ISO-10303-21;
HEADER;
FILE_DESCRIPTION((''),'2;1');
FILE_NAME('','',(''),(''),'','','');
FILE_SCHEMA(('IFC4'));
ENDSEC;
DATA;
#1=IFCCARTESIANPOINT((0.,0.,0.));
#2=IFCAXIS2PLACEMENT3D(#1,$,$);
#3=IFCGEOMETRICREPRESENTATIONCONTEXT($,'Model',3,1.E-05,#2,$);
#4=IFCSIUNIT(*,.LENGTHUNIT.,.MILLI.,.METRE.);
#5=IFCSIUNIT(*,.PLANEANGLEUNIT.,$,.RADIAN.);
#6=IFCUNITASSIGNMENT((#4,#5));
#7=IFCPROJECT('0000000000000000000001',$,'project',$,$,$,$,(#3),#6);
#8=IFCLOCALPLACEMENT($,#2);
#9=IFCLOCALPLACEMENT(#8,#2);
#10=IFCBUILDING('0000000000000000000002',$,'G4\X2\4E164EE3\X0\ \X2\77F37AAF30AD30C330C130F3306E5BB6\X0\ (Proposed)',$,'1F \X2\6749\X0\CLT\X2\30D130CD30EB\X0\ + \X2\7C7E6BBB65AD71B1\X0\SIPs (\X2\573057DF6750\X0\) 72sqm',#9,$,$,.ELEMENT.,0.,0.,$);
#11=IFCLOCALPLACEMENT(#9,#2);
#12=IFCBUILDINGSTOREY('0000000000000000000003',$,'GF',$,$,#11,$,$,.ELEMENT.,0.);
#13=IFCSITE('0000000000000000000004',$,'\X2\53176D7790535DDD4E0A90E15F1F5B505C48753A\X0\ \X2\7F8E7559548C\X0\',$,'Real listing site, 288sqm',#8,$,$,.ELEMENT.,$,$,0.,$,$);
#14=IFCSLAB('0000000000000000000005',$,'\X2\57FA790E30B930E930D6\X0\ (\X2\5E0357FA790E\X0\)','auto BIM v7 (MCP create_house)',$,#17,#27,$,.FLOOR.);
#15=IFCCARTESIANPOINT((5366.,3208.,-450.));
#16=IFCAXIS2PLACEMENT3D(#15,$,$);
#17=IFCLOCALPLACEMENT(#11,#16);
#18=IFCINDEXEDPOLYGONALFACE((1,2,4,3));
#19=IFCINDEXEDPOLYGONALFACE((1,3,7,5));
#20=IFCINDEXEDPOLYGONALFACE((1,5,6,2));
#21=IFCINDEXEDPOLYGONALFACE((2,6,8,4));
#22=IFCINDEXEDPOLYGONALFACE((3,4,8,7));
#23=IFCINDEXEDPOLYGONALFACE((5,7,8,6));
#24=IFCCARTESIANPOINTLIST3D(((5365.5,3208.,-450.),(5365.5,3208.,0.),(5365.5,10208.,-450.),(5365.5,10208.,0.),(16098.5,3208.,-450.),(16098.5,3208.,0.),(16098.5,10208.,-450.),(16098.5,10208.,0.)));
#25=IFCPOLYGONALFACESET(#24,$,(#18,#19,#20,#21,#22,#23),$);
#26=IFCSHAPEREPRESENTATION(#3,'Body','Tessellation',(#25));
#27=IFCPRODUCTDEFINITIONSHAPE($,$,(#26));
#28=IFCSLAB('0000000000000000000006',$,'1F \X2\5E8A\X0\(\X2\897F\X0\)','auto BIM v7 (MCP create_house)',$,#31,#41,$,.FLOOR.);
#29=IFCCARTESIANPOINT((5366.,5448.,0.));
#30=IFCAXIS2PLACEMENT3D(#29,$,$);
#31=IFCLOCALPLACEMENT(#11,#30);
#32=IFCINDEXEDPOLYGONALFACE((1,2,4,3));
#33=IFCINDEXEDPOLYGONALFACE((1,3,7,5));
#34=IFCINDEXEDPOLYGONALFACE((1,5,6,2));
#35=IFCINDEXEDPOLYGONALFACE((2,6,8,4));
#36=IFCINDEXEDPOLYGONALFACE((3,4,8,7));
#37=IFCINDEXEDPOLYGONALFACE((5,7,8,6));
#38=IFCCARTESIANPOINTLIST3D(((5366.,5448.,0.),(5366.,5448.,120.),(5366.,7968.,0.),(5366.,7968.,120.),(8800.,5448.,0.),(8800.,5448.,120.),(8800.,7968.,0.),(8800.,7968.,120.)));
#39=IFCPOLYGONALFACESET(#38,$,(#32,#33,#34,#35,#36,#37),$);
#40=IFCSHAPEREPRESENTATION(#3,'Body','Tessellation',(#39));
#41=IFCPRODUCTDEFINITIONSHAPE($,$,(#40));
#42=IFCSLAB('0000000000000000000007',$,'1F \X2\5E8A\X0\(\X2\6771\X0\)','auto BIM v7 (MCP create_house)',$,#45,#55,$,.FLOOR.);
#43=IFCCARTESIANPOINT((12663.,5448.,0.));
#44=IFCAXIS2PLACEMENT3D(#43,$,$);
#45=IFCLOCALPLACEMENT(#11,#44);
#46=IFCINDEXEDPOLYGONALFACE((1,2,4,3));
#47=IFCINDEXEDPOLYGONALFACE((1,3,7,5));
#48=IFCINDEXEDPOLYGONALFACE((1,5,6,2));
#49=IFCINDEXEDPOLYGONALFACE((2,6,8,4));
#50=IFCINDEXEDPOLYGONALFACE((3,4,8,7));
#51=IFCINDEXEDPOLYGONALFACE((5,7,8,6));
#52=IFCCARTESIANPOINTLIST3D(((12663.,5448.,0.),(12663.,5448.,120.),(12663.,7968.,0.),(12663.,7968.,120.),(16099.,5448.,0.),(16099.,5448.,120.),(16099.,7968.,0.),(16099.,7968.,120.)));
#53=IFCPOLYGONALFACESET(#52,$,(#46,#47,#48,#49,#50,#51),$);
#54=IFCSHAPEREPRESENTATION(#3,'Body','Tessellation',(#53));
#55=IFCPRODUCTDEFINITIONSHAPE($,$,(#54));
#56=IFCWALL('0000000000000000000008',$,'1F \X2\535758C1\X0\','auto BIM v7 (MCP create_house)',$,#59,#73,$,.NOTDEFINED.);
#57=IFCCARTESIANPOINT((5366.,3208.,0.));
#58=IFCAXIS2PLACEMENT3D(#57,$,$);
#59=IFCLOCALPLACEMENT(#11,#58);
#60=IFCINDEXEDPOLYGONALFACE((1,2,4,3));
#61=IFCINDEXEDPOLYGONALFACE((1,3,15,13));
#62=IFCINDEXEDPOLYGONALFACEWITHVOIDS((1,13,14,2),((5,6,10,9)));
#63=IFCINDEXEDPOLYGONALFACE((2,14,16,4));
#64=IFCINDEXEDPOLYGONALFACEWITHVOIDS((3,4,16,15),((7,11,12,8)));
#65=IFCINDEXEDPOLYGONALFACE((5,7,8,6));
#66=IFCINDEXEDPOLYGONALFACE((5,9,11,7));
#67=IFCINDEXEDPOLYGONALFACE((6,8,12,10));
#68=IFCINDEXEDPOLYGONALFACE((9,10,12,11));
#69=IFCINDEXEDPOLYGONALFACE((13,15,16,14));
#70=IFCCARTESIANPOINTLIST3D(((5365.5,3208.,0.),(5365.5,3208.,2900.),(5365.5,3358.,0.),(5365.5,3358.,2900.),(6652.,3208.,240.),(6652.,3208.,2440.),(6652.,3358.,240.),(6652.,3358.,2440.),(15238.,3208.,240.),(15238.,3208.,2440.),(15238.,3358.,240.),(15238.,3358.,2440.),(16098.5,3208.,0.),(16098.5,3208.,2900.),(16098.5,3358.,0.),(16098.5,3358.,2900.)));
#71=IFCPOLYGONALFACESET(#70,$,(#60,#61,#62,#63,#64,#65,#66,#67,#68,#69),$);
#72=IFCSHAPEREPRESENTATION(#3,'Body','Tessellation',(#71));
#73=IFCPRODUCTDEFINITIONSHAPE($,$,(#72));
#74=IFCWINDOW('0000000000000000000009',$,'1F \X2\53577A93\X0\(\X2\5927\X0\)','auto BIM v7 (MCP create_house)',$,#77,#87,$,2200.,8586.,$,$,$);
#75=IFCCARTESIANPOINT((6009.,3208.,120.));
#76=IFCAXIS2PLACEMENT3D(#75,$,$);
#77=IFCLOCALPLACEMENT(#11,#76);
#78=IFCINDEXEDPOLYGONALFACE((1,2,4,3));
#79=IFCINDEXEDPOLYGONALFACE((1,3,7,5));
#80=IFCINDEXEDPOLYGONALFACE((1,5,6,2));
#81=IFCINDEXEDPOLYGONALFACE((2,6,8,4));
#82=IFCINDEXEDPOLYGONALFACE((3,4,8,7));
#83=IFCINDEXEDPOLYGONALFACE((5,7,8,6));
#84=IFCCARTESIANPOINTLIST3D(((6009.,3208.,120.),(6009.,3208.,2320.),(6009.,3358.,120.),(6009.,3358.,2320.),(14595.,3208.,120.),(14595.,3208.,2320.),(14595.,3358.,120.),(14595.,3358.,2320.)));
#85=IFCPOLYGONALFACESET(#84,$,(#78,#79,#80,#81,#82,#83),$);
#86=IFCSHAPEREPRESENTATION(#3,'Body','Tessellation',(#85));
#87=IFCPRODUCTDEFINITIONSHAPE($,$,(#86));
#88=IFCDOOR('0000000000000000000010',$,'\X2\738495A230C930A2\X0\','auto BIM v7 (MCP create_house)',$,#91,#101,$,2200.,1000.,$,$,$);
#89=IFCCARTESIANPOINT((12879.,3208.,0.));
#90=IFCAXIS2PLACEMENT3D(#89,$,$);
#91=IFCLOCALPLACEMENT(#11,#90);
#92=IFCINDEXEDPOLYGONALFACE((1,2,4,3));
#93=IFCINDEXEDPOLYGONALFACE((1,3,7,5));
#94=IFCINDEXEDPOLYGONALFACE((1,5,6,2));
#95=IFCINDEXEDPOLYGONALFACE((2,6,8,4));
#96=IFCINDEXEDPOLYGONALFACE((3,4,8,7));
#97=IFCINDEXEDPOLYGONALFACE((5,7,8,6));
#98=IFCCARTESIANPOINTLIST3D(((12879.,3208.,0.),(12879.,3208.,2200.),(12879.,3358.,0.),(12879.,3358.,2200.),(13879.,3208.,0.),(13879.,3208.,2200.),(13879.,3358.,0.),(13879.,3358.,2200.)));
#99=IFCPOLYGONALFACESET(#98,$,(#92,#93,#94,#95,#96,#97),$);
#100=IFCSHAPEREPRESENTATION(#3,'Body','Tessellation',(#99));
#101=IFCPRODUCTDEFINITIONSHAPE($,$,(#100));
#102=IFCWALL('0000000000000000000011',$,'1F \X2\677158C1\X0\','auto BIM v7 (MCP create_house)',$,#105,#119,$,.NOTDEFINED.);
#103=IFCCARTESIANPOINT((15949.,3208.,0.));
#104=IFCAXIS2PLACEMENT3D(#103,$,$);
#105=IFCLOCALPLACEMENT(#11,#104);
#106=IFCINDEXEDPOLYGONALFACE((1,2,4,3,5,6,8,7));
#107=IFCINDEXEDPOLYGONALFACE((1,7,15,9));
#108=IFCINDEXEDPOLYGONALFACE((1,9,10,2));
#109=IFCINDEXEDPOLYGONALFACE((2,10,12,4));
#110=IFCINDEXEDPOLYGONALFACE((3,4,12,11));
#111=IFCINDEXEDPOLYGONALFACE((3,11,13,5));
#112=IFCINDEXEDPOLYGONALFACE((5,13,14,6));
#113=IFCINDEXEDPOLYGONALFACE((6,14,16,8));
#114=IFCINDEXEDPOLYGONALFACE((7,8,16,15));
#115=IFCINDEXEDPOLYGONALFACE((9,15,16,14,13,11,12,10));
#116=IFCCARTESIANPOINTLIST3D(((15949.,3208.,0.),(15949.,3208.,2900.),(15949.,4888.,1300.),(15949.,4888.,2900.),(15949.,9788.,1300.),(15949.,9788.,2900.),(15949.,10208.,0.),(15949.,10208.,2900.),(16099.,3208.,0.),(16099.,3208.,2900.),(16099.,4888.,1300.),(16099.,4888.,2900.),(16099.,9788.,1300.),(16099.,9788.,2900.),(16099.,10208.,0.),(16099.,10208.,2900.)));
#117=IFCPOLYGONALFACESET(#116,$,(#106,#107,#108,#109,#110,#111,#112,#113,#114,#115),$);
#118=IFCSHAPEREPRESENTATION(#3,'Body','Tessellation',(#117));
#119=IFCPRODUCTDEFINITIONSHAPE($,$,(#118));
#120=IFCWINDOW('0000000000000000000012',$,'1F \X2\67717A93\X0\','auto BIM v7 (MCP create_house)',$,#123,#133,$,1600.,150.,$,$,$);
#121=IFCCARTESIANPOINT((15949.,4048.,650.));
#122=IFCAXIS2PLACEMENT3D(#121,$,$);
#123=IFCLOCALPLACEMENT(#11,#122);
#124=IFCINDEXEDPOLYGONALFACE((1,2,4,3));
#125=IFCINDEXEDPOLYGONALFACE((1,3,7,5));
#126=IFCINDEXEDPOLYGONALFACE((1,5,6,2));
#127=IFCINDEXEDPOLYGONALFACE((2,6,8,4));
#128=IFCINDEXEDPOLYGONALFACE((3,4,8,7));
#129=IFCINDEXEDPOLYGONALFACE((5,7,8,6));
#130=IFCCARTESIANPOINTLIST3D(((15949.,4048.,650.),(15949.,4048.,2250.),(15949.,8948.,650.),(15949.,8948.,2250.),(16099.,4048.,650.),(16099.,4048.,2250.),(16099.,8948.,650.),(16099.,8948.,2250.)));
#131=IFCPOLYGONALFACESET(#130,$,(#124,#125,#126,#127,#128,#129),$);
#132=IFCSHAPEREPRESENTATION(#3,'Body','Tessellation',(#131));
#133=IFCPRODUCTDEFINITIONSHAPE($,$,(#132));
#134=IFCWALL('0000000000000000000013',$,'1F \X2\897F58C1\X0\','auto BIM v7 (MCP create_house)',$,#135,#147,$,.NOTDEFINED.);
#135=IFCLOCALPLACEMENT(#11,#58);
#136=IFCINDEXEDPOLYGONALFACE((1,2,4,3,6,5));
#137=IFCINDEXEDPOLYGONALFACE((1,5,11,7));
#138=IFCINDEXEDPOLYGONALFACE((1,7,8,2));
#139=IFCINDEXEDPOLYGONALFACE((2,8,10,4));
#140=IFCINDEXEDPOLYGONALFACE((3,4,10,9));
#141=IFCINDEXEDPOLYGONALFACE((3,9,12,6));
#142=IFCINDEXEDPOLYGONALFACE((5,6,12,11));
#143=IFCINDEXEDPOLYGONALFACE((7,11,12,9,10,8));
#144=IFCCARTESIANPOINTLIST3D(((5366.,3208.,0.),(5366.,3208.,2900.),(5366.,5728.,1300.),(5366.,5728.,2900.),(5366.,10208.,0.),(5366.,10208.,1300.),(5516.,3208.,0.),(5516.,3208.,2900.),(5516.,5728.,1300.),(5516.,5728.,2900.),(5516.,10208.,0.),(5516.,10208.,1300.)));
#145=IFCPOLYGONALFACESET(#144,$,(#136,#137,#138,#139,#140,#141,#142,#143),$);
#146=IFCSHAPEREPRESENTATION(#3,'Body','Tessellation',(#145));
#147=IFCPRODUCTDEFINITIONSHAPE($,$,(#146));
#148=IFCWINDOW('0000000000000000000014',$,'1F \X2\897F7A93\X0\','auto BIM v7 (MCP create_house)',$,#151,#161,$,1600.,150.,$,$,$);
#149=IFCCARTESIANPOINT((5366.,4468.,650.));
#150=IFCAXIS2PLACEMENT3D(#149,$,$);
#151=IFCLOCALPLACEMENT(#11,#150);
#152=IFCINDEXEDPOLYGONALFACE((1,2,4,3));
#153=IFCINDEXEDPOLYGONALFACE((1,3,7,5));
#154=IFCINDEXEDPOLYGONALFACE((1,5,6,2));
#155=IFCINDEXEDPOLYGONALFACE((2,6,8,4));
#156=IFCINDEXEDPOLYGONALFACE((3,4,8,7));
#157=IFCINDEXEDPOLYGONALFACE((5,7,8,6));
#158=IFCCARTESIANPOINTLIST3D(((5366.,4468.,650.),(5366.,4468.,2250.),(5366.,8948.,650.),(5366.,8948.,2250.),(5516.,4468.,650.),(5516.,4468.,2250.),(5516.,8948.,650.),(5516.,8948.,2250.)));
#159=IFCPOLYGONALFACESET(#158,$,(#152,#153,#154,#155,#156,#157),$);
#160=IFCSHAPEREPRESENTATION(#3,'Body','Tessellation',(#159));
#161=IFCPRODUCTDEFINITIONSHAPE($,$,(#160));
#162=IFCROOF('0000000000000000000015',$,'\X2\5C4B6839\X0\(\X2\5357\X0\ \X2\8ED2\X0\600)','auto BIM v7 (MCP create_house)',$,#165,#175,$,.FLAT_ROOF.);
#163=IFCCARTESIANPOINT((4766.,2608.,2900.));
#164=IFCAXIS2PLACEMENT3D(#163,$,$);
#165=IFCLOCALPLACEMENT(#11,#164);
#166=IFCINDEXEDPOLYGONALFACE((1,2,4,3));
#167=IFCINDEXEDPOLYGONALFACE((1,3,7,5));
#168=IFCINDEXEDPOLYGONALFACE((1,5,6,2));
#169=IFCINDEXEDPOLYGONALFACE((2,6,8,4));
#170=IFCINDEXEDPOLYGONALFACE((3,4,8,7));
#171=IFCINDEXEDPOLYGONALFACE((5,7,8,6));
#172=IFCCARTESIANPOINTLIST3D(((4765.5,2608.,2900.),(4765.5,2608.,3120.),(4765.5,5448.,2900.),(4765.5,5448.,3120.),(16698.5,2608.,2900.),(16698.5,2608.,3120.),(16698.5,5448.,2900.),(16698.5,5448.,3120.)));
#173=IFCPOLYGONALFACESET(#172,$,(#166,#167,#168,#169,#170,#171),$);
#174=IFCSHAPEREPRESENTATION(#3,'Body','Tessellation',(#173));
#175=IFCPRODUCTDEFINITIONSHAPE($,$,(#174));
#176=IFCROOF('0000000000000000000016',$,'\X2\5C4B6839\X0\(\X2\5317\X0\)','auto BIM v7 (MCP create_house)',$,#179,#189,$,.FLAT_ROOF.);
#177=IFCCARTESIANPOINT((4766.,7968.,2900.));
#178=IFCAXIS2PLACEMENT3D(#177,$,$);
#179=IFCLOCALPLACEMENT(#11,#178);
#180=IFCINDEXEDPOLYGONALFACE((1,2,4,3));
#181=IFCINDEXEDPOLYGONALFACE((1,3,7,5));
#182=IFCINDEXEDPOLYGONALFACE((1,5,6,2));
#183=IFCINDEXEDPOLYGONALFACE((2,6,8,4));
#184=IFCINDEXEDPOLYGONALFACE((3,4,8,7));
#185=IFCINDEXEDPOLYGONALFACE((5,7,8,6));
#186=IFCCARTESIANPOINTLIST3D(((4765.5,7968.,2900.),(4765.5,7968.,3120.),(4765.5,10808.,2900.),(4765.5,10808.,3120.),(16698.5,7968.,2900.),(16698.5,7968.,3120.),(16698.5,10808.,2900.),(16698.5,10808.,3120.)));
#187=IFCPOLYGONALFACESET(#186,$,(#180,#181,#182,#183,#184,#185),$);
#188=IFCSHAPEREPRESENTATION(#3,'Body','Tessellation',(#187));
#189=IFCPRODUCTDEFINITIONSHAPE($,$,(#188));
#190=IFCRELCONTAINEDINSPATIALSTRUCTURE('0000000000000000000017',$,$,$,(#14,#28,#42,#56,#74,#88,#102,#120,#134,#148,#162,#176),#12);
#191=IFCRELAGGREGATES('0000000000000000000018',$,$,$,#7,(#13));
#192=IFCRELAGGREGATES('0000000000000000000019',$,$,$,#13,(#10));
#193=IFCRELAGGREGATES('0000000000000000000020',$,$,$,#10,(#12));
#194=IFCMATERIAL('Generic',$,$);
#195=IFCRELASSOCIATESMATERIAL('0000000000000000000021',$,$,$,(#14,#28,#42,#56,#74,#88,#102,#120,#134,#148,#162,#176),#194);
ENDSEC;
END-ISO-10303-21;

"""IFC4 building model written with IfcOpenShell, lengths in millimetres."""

from ifc_helpers import new_model, si_unit, frame, frame_2d, origin, place, context, project, spatial, rectangle, extrude, material, element, fill, save


model = new_model("IFC4")

# Units and contexts
model_context = context("Model", 3, precision=1e-05, world=origin())
ifc_project = project(units=[si_unit("LENGTHUNIT", "METRE", prefix="MILLI"), si_unit("PLANEANGLEUNIT", "RADIAN")], contexts=[model_context])

# Site, building, storey
site_placement = place(None, origin())
site = spatial("IfcSite", under=ifc_project, at=site_placement, Name="北海道川上郡弟子屈町 美留和", ObjectType="Real listing site, 288sqm", CompositionType="ELEMENT", RefElevation=0.0)
building_placement = place(site_placement, origin())
building = spatial("IfcBuilding", under=site, at=building_placement, Name="G4世代 石窯キッチンの家 (Proposed)", ObjectType="1F 杉CLTパネル + 籾殻断熱SIPs (地域材) 72sqm", CompositionType="ELEMENT", ElevationOfRefHeight=0.0, ElevationOfTerrain=0.0)
storey_placement = place(building_placement, origin())
storey = spatial("IfcBuildingStorey", under=building, at=storey_placement, Name="GF", CompositionType="ELEMENT", Elevation=0.0)

# Slabs
ifc_material = material(Name="Generic")
slab_1_placement = place(storey_placement, frame((5366.0, 3208.0, -450.0)))
element("IfcSlab", 1, at=slab_1_placement, inside=storey, material=ifc_material, Name="基礎スラブ (布基礎)", Description="auto BIM v7 (MCP create_house)", PredefinedType="FLOOR", context=model_context, shape_type="SweptSolid", body=[
    extrude(rectangle(XDim=10733.0, YDim=7000.0, at=frame_2d((5366.0, 3500.0))), frame((5366.0, 3208.0, -450.0)), (0.0, 0.0, 1.0), 450.0),
])
slab_2_placement = place(storey_placement, frame((5366.0, 5448.0, 0.0)))
element("IfcSlab", 2, at=slab_2_placement, inside=storey, material=ifc_material, Name="1F 床(西)", Description="auto BIM v7 (MCP create_house)", PredefinedType="FLOOR", context=model_context, shape_type="SweptSolid", body=[
    extrude(rectangle(XDim=3434.0, YDim=2520.0, at=frame_2d((1717.0, 1260.0))), frame((5366.0, 5448.0, 0.0)), (0.0, 0.0, 1.0), 120.0),
])
slab_3_placement = place(storey_placement, frame((12663.0, 5448.0, 0.0)))
element("IfcSlab", 3, at=slab_3_placement, inside=storey, material=ifc_material, Name="1F 床(東)", Description="auto BIM v7 (MCP create_house)", PredefinedType="FLOOR", context=model_context, shape_type="SweptSolid", body=[
    extrude(rectangle(XDim=3436.0, YDim=2520.0, at=frame_2d((1718.0, 1260.0))), frame((12663.0, 5448.0, 0.0)), (0.0, 0.0, 1.0), 120.0),
])

# Wall, openings, window, door
wall_1_placement = place(storey_placement, frame((5366.0, 3208.0, 0.0)))
wall_1 = element("IfcWall", 4, at=wall_1_placement, inside=storey, material=ifc_material, Name="1F 南壁", Description="auto BIM v7 (MCP create_house)", PredefinedType="NOTDEFINED", context=model_context, shape_type="SweptSolid", body=[
    extrude(rectangle(XDim=10733.0, YDim=150.0, at=frame_2d((5366.0, 75.0))), frame((5366.0, 3208.0, 0.0)), (0.0, 0.0, 1.0), 2900.0),
])
opening_1_placement = place(storey_placement, frame((6009.0, 3208.0, 120.0)))
opening_1 = element("IfcOpeningElement", 5, at=opening_1_placement, cuts=wall_1, PredefinedType="NOTDEFINED", context=model_context, shape_type="SweptSolid", body=[
    extrude(rectangle(XDim=8586.0, YDim=150.0, at=frame_2d((4293.0, 75.0))), frame((6009.0, 3208.0, 120.0)), (0.0, 0.0, 1.0), 2200.0),
])
opening_2_placement = place(storey_placement, frame((12879.0, 3208.0, 0.0)))
opening_2 = element("IfcOpeningElement", 6, at=opening_2_placement, cuts=wall_1, PredefinedType="NOTDEFINED", context=model_context, shape_type="SweptSolid", body=[
    extrude(rectangle(XDim=1000.0, YDim=150.0, at=frame_2d((500.0, 75.0))), frame((12879.0, 3208.0, 0.0)), (0.0, 0.0, 1.0), 2200.0),
])
window_1_placement = place(storey_placement, frame((6009.0, 3208.0, 120.0)))
window_1 = element("IfcWindow", 7, at=window_1_placement, inside=storey, material=ifc_material, Name="1F 南窓(大)", Description="auto BIM v7 (MCP create_house)", OverallHeight=2200.0, OverallWidth=8586.0, context=model_context, shape_type="SweptSolid", body=[
    extrude(rectangle(XDim=8586.0, YDim=150.0, at=frame_2d((4293.0, 75.0))), frame((6009.0, 3208.0, 120.0)), (0.0, 0.0, 1.0), 2200.0),
])
fill(opening_1, window_1)
door_placement = place(storey_placement, frame((12879.0, 3208.0, 0.0)))
door = element("IfcDoor", 8, at=door_placement, inside=storey, material=ifc_material, Name="玄関ドア", Description="auto BIM v7 (MCP create_house)", OverallHeight=2200.0, OverallWidth=1000.0, context=model_context, shape_type="SweptSolid", body=[
    extrude(rectangle(XDim=1000.0, YDim=150.0, at=frame_2d((500.0, 75.0))), frame((12879.0, 3208.0, 0.0)), (0.0, 0.0, 1.0), 2200.0),
])
fill(opening_2, door)

# Walls, openings, windows
wall_2_placement = place(storey_placement, frame((15949.0, 3208.0, 0.0)))
wall_2 = element("IfcWall", 9, at=wall_2_placement, inside=storey, material=ifc_material, Name="1F 東壁", Description="auto BIM v7 (MCP create_house)", PredefinedType="NOTDEFINED", context=model_context, shape_type="SweptSolid", body=[
    extrude(rectangle(XDim=150.0, YDim=7000.0, at=frame_2d((75.0, 3500.0))), frame((15949.0, 3208.0, 0.0)), (0.0, 0.0, 1.0), 2900.0),
])
opening_3_placement = place(storey_placement, frame((15949.0, 4048.0, 650.0)))
opening_3 = element("IfcOpeningElement", 10, at=opening_3_placement, cuts=wall_2, PredefinedType="NOTDEFINED", context=model_context, shape_type="SweptSolid", body=[
    extrude(rectangle(XDim=150.0, YDim=4900.0, at=frame_2d((75.0, 2450.0))), frame((15949.0, 4048.0, 650.0)), (0.0, 0.0, 1.0), 1600.0),
])
window_2_placement = place(storey_placement, frame((15949.0, 4048.0, 650.0)))
window_2 = element("IfcWindow", 11, at=window_2_placement, inside=storey, material=ifc_material, Name="1F 東窓", Description="auto BIM v7 (MCP create_house)", OverallHeight=1600.0, OverallWidth=150.0, context=model_context, shape_type="SweptSolid", body=[
    extrude(rectangle(XDim=150.0, YDim=4900.0, at=frame_2d((75.0, 2450.0))), frame((15949.0, 4048.0, 650.0)), (0.0, 0.0, 1.0), 1600.0),
])
fill(opening_3, window_2)
wall_3_placement = place(storey_placement, frame((5366.0, 3208.0, 0.0)))
wall_3 = element("IfcWall", 12, at=wall_3_placement, inside=storey, material=ifc_material, Name="1F 西壁", Description="auto BIM v7 (MCP create_house)", PredefinedType="NOTDEFINED", context=model_context, shape_type="SweptSolid", body=[
    extrude(rectangle(XDim=150.0, YDim=7000.0, at=frame_2d((75.0, 3500.0))), frame((5366.0, 3208.0, 0.0)), (0.0, 0.0, 1.0), 2900.0),
])
opening_4_placement = place(storey_placement, frame((5366.0, 4468.0, 650.0)))
opening_4 = element("IfcOpeningElement", 13, at=opening_4_placement, cuts=wall_3, PredefinedType="NOTDEFINED", context=model_context, shape_type="SweptSolid", body=[
    extrude(rectangle(XDim=150.0, YDim=4480.0, at=frame_2d((75.0, 2240.0))), frame((5366.0, 4468.0, 650.0)), (0.0, 0.0, 1.0), 1600.0),
])
window_3_placement = place(storey_placement, frame((5366.0, 4468.0, 650.0)))
window_3 = element("IfcWindow", 14, at=window_3_placement, inside=storey, material=ifc_material, Name="1F 西窓", Description="auto BIM v7 (MCP create_house)", OverallHeight=1600.0, OverallWidth=150.0, context=model_context, shape_type="SweptSolid", body=[
    extrude(rectangle(XDim=150.0, YDim=4480.0, at=frame_2d((75.0, 2240.0))), frame((5366.0, 4468.0, 650.0)), (0.0, 0.0, 1.0), 1600.0),
])
fill(opening_4, window_3)

# Roofs
roof_1_placement = place(storey_placement, frame((4766.0, 2608.0, 2900.0)))
element("IfcRoof", 15, at=roof_1_placement, inside=storey, material=ifc_material, Name="屋根(南 軒600)", Description="auto BIM v7 (MCP create_house)", PredefinedType="FLAT_ROOF", context=model_context, shape_type="SweptSolid", body=[
    extrude(rectangle(XDim=11933.0, YDim=2840.0, at=frame_2d((5966.0, 1420.0))), frame((4766.0, 2608.0, 2900.0)), (0.0, 0.0, 1.0), 220.0),
])
roof_2_placement = place(storey_placement, frame((4766.0, 7968.0, 2900.0)))
element("IfcRoof", 16, at=roof_2_placement, inside=storey, material=ifc_material, Name="屋根(北)", Description="auto BIM v7 (MCP create_house)", PredefinedType="FLAT_ROOF", context=model_context, shape_type="SweptSolid", body=[
    extrude(rectangle(XDim=11933.0, YDim=2840.0, at=frame_2d((5966.0, 1420.0))), frame((4766.0, 7968.0, 2900.0)), (0.0, 0.0, 1.0), 220.0),
])

save(model, "model.ifc")
